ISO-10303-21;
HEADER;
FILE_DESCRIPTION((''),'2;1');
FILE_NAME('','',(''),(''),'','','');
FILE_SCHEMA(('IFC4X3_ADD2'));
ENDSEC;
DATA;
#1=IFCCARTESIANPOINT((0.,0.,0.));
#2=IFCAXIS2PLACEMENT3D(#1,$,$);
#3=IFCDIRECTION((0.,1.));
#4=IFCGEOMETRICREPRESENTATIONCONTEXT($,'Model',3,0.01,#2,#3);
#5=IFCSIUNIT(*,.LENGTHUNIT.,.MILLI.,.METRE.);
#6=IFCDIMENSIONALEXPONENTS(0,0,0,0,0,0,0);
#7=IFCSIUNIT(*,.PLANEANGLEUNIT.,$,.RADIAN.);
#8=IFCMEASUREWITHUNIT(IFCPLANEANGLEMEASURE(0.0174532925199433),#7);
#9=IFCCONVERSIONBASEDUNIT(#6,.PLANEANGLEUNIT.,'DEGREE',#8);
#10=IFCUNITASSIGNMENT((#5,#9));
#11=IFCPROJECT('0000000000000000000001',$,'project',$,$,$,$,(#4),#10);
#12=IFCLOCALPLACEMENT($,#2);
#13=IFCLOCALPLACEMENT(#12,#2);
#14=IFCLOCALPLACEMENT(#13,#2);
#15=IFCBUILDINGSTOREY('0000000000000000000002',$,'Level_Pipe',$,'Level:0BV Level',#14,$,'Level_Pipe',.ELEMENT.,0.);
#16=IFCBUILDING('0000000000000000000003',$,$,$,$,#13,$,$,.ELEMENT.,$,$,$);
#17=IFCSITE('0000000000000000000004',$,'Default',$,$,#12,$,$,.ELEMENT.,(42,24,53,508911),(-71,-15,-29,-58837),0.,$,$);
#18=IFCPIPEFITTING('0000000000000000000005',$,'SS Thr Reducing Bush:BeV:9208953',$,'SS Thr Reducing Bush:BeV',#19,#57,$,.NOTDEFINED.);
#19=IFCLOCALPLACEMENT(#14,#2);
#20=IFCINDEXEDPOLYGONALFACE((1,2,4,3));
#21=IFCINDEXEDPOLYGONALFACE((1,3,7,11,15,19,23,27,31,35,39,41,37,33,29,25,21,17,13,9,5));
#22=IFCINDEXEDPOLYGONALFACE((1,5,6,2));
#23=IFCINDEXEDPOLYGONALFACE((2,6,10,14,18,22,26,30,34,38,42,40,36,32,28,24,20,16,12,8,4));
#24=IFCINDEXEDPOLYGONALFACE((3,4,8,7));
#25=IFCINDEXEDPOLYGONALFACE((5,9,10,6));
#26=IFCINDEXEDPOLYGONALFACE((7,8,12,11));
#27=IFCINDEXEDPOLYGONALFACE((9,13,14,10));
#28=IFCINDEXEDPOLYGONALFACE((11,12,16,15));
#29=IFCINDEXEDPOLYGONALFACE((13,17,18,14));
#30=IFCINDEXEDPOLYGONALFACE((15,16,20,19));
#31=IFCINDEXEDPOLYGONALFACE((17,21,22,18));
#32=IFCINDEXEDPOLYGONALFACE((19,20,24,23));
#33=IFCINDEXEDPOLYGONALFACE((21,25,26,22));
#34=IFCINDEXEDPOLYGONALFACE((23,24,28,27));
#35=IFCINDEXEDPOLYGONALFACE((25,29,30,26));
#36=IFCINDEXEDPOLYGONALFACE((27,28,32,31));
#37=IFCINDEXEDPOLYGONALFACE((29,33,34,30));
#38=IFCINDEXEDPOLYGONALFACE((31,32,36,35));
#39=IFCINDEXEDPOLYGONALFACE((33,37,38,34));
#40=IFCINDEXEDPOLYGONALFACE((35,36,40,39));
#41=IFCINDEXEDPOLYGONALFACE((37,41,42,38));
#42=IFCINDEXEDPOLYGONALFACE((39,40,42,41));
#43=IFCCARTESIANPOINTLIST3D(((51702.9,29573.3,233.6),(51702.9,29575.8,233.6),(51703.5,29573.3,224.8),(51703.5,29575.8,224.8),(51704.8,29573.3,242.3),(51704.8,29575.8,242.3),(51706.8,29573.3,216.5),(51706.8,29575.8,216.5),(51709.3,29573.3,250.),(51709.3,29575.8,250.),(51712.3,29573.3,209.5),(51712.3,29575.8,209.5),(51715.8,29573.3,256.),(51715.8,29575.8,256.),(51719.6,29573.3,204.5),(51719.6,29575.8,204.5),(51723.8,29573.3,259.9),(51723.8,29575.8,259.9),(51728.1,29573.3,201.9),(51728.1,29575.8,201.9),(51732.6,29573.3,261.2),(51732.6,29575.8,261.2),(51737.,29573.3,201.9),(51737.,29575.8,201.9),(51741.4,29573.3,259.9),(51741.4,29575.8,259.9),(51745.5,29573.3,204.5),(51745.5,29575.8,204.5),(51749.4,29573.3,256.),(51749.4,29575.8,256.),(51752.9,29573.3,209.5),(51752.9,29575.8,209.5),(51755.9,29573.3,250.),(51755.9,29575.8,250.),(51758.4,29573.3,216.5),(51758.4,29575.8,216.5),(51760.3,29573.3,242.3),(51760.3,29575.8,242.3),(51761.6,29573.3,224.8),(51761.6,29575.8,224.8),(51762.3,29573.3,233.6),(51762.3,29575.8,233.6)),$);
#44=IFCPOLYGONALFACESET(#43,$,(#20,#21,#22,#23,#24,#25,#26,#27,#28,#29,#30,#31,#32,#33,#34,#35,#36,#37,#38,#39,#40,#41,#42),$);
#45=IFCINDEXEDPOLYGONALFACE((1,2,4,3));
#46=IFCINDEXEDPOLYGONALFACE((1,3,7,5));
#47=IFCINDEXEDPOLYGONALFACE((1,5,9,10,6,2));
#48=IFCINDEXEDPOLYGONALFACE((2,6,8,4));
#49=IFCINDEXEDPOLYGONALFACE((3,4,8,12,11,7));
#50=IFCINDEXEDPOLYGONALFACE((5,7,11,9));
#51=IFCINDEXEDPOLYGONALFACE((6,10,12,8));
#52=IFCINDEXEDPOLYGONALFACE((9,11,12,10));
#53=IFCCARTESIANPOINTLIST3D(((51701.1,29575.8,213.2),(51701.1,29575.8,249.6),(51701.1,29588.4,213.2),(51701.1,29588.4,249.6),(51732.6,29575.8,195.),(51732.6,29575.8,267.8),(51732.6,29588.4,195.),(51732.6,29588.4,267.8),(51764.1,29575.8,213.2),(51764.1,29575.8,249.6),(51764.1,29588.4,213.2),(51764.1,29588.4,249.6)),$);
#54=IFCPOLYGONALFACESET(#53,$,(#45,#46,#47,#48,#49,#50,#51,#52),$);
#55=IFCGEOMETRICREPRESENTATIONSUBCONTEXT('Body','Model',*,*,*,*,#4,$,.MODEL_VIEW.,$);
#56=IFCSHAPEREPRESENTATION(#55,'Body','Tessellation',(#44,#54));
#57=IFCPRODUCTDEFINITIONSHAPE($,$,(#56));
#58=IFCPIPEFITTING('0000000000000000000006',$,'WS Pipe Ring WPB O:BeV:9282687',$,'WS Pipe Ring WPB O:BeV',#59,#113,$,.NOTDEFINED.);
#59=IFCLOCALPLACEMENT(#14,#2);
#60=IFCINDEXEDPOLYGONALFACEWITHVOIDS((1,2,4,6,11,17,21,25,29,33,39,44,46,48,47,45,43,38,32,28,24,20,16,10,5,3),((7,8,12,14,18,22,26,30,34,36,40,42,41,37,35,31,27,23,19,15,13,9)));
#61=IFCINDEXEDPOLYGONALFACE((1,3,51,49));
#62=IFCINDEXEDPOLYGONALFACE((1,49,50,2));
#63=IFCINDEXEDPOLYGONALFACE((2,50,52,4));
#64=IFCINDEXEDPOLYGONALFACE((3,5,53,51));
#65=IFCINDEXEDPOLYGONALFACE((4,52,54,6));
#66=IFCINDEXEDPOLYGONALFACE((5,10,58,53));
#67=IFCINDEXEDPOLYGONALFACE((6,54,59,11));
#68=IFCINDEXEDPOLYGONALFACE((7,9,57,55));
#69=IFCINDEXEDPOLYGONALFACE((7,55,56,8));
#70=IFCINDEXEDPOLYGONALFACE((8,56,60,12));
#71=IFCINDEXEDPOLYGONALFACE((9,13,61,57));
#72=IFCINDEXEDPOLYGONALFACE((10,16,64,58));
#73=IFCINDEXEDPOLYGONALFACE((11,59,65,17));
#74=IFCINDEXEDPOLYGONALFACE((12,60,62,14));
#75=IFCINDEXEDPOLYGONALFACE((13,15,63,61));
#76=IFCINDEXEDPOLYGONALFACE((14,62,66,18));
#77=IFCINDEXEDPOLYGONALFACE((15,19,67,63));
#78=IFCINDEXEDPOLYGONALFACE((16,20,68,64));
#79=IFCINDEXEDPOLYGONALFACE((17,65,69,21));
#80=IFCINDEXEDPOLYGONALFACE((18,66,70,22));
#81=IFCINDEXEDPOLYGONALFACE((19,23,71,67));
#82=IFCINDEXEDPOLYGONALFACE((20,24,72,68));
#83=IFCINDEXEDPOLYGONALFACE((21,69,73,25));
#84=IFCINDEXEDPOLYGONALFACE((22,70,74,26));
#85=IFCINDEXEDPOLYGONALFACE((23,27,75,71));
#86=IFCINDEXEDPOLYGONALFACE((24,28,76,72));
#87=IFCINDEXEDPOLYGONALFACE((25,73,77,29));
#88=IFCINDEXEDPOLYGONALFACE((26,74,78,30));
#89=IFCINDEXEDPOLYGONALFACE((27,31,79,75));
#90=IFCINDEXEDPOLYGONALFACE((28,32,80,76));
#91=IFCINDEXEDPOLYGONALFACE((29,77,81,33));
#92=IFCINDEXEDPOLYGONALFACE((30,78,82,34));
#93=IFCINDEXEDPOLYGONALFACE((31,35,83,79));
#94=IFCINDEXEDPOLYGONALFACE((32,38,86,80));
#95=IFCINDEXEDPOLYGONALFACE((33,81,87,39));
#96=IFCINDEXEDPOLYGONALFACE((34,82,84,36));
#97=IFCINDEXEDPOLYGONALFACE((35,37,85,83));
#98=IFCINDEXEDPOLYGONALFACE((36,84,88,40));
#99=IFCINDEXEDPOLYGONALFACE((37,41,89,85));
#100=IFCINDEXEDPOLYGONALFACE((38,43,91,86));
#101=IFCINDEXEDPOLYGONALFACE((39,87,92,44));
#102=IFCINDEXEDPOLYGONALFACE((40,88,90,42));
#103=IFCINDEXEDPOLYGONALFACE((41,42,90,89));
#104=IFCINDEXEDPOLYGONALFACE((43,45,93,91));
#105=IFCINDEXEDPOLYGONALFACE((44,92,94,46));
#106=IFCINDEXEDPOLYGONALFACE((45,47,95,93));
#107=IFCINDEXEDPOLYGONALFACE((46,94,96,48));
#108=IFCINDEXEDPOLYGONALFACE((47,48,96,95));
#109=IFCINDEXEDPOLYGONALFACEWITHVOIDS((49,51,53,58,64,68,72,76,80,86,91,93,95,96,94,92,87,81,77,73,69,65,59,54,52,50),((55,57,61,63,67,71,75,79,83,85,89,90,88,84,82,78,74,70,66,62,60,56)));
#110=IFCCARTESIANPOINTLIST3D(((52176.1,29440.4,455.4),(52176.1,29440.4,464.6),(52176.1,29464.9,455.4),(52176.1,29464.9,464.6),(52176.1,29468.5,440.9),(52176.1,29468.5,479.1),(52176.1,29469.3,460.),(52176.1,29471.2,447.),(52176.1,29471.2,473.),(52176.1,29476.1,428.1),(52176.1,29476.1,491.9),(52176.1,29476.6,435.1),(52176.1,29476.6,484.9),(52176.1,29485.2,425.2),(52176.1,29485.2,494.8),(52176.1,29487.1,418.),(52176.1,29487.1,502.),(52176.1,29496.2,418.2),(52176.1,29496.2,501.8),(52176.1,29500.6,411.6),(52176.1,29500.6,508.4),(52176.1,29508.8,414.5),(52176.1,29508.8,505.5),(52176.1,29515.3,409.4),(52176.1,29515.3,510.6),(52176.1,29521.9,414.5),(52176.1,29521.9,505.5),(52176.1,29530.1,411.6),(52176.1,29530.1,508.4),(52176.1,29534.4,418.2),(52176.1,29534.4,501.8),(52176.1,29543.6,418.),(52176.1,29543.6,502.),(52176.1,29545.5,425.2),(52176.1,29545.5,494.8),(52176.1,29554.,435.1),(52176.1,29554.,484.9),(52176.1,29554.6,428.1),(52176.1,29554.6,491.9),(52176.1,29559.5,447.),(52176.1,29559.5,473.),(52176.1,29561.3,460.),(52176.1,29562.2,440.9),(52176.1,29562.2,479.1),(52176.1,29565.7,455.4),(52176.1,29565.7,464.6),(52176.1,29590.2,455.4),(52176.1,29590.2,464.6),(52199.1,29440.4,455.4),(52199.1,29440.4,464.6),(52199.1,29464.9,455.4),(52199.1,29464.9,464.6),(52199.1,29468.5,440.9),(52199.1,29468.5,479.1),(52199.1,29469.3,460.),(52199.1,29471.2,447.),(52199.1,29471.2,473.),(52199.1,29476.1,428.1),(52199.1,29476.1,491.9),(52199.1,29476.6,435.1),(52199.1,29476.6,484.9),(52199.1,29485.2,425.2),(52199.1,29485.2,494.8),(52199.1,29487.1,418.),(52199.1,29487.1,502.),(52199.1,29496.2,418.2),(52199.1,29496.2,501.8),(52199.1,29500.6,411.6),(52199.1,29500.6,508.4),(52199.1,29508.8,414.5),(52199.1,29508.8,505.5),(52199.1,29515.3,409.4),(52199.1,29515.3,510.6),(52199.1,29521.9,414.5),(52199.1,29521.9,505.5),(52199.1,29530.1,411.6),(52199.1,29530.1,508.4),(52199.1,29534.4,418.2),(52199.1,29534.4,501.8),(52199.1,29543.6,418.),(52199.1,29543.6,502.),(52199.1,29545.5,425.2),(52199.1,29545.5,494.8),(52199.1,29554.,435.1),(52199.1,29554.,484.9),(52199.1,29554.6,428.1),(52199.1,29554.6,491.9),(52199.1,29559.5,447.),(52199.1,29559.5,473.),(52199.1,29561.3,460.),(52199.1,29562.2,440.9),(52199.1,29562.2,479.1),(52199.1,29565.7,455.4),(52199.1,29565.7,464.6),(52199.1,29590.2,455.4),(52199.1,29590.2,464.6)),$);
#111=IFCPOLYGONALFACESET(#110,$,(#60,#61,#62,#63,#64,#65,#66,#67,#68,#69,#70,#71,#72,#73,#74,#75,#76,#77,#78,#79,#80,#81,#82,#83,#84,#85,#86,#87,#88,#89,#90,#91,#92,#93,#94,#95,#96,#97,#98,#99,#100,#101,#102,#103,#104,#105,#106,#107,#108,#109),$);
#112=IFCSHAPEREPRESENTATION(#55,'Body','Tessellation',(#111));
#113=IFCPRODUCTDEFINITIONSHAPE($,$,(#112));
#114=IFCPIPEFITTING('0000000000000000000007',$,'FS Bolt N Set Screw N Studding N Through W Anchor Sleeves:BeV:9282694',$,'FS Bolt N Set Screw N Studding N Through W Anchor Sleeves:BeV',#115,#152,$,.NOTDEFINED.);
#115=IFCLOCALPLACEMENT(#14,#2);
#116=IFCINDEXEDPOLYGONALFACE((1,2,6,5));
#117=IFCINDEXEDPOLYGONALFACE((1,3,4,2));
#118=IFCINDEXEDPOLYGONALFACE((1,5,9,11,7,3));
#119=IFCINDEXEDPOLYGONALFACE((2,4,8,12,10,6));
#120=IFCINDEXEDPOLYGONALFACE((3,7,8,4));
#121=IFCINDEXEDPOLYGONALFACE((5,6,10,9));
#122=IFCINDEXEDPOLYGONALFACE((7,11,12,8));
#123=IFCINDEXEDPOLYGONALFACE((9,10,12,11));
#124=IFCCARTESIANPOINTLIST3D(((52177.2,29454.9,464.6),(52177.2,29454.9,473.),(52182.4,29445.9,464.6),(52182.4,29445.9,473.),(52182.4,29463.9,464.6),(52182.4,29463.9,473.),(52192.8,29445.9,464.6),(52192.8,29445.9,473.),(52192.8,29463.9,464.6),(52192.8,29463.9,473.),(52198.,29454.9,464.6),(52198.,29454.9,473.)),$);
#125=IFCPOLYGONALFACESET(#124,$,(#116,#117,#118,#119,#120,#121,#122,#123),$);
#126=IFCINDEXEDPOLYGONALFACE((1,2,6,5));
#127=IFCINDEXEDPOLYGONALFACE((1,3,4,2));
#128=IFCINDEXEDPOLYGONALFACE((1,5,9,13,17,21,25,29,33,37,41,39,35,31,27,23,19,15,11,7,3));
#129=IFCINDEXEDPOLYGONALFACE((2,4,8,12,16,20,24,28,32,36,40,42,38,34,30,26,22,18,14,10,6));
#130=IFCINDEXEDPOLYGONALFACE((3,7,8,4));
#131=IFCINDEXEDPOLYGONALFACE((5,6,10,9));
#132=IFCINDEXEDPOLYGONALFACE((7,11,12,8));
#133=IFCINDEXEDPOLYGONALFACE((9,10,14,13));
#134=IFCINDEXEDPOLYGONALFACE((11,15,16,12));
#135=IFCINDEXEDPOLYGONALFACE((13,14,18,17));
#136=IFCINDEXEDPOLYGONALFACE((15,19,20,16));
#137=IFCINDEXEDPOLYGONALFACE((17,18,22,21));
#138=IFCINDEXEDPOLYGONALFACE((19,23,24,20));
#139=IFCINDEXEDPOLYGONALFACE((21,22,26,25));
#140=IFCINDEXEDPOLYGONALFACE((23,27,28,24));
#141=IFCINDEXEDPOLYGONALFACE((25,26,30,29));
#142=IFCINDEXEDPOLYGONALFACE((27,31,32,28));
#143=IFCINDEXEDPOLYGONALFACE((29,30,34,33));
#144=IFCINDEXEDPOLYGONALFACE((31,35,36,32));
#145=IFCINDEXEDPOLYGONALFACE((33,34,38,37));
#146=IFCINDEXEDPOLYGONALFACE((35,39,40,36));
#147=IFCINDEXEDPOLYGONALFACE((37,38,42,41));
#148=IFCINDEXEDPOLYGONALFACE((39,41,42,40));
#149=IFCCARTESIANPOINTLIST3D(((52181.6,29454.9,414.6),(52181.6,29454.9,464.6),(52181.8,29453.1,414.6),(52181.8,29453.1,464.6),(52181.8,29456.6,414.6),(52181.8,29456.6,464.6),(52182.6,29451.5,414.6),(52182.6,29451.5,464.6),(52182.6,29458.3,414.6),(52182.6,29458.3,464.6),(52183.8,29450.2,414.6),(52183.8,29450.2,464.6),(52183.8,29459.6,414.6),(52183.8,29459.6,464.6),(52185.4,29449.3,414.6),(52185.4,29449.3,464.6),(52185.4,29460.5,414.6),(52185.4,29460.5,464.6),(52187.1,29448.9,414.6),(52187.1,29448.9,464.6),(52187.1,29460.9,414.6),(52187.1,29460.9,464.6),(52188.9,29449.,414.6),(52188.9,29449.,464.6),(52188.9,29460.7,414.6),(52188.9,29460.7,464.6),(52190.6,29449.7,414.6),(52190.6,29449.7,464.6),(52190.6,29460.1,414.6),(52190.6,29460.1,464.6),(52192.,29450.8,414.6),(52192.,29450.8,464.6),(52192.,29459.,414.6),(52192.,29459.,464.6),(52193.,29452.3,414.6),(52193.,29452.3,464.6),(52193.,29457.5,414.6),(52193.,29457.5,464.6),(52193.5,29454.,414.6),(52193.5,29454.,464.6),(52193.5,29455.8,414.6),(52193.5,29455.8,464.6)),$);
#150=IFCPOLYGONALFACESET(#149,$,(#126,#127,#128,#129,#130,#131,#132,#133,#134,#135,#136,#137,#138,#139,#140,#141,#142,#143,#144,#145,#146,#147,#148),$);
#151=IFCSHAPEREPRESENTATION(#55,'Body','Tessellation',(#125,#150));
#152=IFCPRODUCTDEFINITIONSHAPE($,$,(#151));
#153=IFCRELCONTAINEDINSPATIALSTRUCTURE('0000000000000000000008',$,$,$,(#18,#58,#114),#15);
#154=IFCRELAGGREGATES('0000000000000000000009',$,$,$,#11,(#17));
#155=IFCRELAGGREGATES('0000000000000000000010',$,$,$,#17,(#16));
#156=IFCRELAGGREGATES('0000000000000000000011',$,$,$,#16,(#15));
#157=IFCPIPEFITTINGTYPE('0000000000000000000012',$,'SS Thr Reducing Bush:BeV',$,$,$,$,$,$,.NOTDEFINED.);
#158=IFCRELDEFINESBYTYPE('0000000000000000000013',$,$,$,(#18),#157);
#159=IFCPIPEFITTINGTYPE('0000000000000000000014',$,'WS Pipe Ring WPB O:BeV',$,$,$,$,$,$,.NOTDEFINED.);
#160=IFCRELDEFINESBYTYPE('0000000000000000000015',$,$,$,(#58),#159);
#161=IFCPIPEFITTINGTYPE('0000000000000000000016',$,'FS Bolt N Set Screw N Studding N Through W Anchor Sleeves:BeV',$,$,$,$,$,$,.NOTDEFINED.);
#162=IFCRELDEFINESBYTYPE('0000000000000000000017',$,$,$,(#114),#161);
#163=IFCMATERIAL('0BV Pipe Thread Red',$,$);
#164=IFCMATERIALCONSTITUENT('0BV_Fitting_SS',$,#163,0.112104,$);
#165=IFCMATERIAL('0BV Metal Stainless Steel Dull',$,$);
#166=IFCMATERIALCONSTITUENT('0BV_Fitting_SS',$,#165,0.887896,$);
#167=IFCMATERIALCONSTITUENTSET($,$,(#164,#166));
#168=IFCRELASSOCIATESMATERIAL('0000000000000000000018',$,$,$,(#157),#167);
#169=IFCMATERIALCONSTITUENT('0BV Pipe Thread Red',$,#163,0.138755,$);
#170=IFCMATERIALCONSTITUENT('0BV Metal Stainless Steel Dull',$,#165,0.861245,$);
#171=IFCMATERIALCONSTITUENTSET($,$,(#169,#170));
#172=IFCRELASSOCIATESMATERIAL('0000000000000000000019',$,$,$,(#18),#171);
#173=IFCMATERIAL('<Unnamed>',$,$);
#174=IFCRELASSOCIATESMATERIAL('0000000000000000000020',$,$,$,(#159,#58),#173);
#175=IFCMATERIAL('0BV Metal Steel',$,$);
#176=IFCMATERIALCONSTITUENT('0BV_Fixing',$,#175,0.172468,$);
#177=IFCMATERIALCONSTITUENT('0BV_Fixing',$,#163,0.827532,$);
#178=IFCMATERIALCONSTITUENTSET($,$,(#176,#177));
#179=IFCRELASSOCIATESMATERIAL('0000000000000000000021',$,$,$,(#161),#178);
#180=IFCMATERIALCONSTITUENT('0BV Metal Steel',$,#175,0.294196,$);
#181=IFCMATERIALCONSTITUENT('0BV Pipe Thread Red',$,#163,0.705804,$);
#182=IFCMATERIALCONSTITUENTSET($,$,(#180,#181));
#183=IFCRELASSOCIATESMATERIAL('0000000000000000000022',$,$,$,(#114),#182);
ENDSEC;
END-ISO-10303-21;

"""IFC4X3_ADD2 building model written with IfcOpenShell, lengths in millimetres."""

from ifc_helpers import new_model, entity, si_unit, converted_unit, direction, frame, frame_2d, origin, origin_2d_with_axis, place, context, subcontext, project, spatial, polyline, circle_curve, parameter, trimmed, segment, composite_curve, circle, outline, extrude, source, transform, mapped, material, constituent, constituent_set, type_object, type_shapes, element, save


model = new_model("IFC4X3_ADD2")

# Units and contexts
model_context = context("Model", 3, precision=0.01, world=origin(), true_north=direction((0.0, 1.0)))
body_context = subcontext(model_context, "Body", "Model", "MODEL_VIEW")
ifc_project = project(units=[si_unit("LENGTHUNIT", "METRE", prefix="MILLI"), converted_unit("PLANEANGLEUNIT", "DEGREE", entity("IfcPlaneAngleMeasure", 0.0174532925199433), si_unit("PLANEANGLEUNIT", "RADIAN"), dimensions=[0, 0, 0, 0, 0, 0, 0])], contexts=[model_context])

# Site, building, storey
site_placement = place(None, origin())
site = spatial("IfcSite", under=ifc_project, at=site_placement, Name="Default", CompositionType="ELEMENT", RefLatitude=(42, 24, 53, 508911), RefLongitude=(-71, -15, -29, -58837), RefElevation=0.0)
building_placement = place(site_placement, origin())
building = spatial("IfcBuilding", under=site, at=building_placement, CompositionType="ELEMENT")
storey_placement = place(building_placement, origin())
storey = spatial("IfcBuildingStorey", under=building, at=storey_placement, Name="Level_Pipe", ObjectType="Level:0BV Level", LongName="Level_Pipe", CompositionType="ELEMENT", Elevation=0.0)

# Pipe fittings
ifc_material_1 = material(Name="0BV Metal Stainless Steel Dull")
ifc_material_2 = material(Name="0BV Metal Steel")
ifc_material_3 = material(Name="0BV Pipe Thread Red")
ifc_constituent_1 = constituent(ifc_material_3, Name="0BV Pipe Thread Red", fraction=0.138755)
ifc_constituent_2 = constituent(ifc_material_1, Name="0BV Metal Stainless Steel Dull", fraction=0.861245)
ifc_constituent_set_1 = constituent_set(constituents=[ifc_constituent_1, ifc_constituent_2])
ifc_constituent_3 = constituent(ifc_material_3, Name="0BV_Fitting_SS", fraction=0.112104)
ifc_constituent_4 = constituent(ifc_material_1, Name="0BV_Fitting_SS", fraction=0.887896)
ifc_constituent_set_2 = constituent_set(constituents=[ifc_constituent_3, ifc_constituent_4])
pipe_fitting_type_1 = type_object("IfcPipeFittingType", Name="SS Thr Reducing Bush:BeV", PredefinedType="NOTDEFINED", material=ifc_constituent_set_2)
shared_shape_1 = source(origin(), body_context, "Body", "SweptSolid", [
    extrude(circle(Radius=29.8, at=frame_2d((0.0, 0.0), x_axis=(1.0, 0.0))), frame((12.6, 0.0, 0.0), z_axis=(1.0, 0.0, 0.0), x_axis=(0.0, -1.0, 0.0)), (0.0, 0.0, 1.0), 2.5),
    extrude(outline(polyline([(-18.2, -31.5), (18.2, -31.5), (36.4, 0.0), (18.2, 31.5), (-18.2, 31.5), (-36.4, 0.0), (-18.2, -31.5)])), frame((0.0, 0.0, 0.0), z_axis=(1.0, 0.0, 0.0), x_axis=(0.0, -1.0, 0.0)), (0.0, 0.0, 1.0), 12.6),
])
type_shapes(pipe_fitting_type_1, [shared_shape_1])
pipe_fitting_1_placement = place(storey_placement, frame((51732.6, 29588.4, 231.4), z_axis=(1.0, 0.0, 0.0), x_axis=(0.0, -1.0, 0.000003)))
element("IfcPipeFitting", 1, at=pipe_fitting_1_placement, inside=storey, type_object=pipe_fitting_type_1, material=ifc_constituent_set_1, Name="SS Thr Reducing Bush:BeV:9208953", ObjectType="SS Thr Reducing Bush:BeV", PredefinedType="NOTDEFINED", context=body_context, shape_type="MappedRepresentation", body=[
    mapped(shared_shape_1, transform((0.0, 0.0, 0.0), scale=1.0)),
])
ifc_material_4 = material(Name="<Unnamed>")
pipe_fitting_type_2 = type_object("IfcPipeFittingType", Name="WS Pipe Ring WPB O:BeV", PredefinedType="NOTDEFINED", material=ifc_material_4)
shared_shape_2 = source(origin(), body_context, "Body", "SweptSolid", [
    extrude(outline(composite_curve([segment(trimmed(circle_curve(origin_2d_with_axis(), 50.6), [parameter(185.215909)], [parameter(354.784091)], True, "PARAMETER"), True, "CONTINUOUS"), segment(polyline([(50.4, -4.6), (74.9, -4.6)]), True, "CONTINUOUS"), segment(polyline([(74.9, -4.6), (74.9, 4.6)]), True, "CONTINUOUS"), segment(polyline([(74.9, 4.6), (50.4, 4.6)]), True, "CONTINUOUS"), segment(trimmed(circle_curve(origin_2d_with_axis(), 50.6), [parameter(5.215909)], [parameter(174.784091)], True, "PARAMETER"), True, "CONTINUOUS"), segment(polyline([(-50.4, 4.6), (-74.9, 4.6)]), True, "CONTINUOUS"), segment(polyline([(-74.9, 4.6), (-74.9, -4.6)]), True, "CONTINUOUS"), segment(polyline([(-74.9, -4.6), (-50.4, -4.6)]), True, "CONTINUOUS")], self_intersect=False), holes=[composite_curve([segment(trimmed(circle_curve(origin_2d_with_axis(), 46.0), [parameter(0.0)], [parameter(180.0)], True, "PARAMETER"), False, "CONTINUOUS"), segment(trimmed(circle_curve(origin_2d_with_axis(), 46.0), [parameter(180.0)], [parameter(360.0)], True, "PARAMETER"), False, "CONTINUOUS")], self_intersect=False)]), frame((0.0, -11.5, 0.0), z_axis=(0.0, 1.0, 0.0), x_axis=(1.0, 0.0, 0.0)), (0.0, 0.0, 1.0), 23.0),
])
type_shapes(pipe_fitting_type_2, [shared_shape_2])
pipe_fitting_2_placement = place(storey_placement, frame((52187.6, 29515.3, 460.0), z_axis=(0.0, 0.0, 1.0), x_axis=(0.0, -1.0, 0.0)))
element("IfcPipeFitting", 2, at=pipe_fitting_2_placement, inside=storey, type_object=pipe_fitting_type_2, material=ifc_material_4, Name="WS Pipe Ring WPB O:BeV:9282687", ObjectType="WS Pipe Ring WPB O:BeV", PredefinedType="NOTDEFINED", context=body_context, shape_type="MappedRepresentation", body=[
    mapped(shared_shape_2, transform((0.0, 0.0, 0.0), scale=1.0)),
])
ifc_constituent_5 = constituent(ifc_material_2, Name="0BV Metal Steel", fraction=0.294196)
ifc_constituent_6 = constituent(ifc_material_3, Name="0BV Pipe Thread Red", fraction=0.705804)
ifc_constituent_set_3 = constituent_set(constituents=[ifc_constituent_5, ifc_constituent_6])
ifc_constituent_7 = constituent(ifc_material_2, Name="0BV_Fixing", fraction=0.172468)
ifc_constituent_8 = constituent(ifc_material_3, Name="0BV_Fixing", fraction=0.827532)
ifc_constituent_set_4 = constituent_set(constituents=[ifc_constituent_7, ifc_constituent_8])
pipe_fitting_type_3 = type_object("IfcPipeFittingType", Name="FS Bolt N Set Screw N Studding N Through W Anchor Sleeves:BeV", PredefinedType="NOTDEFINED", material=ifc_constituent_set_4)
shared_shape_3 = source(origin(), body_context, "Body", "SweptSolid", [
    extrude(outline(polyline([(-5.2, -9.0), (5.2, -9.0), (10.4, 0.0), (5.2, 9.0), (-5.2, 9.0), (-10.4, 0.0), (-5.2, -9.0)])), frame((-8.4, 0.0, 0.0), z_axis=(1.0, 0.0, 0.0), x_axis=(0.0, -1.0, 0.0)), (0.0, 0.0, 1.0), 8.4),
    extrude(circle(Radius=6.0, at=frame_2d((0.0, 0.0), x_axis=(1.0, 0.0))), frame((0.0, 0.0, 0.0), z_axis=(1.0, 0.0, 0.0), x_axis=(0.0, -1.0, 0.0)), (0.0, 0.0, 1.0), 50.0),
])
type_shapes(pipe_fitting_type_3, [shared_shape_3])
pipe_fitting_3_placement = place(storey_placement, frame((52187.6, 29454.9, 464.6), z_axis=(0.0, -1.0, 0.0), x_axis=(0.0, 0.0, -1.0)))
element("IfcPipeFitting", 3, at=pipe_fitting_3_placement, inside=storey, type_object=pipe_fitting_type_3, material=ifc_constituent_set_3, Name="FS Bolt N Set Screw N Studding N Through W Anchor Sleeves:BeV:9282694", ObjectType="FS Bolt N Set Screw N Studding N Through W Anchor Sleeves:BeV", PredefinedType="NOTDEFINED", context=body_context, shape_type="MappedRepresentation", body=[
    mapped(shared_shape_3, transform((0.0, 0.0, 0.0), scale=1.0)),
])

save(model, "model.ifc")
